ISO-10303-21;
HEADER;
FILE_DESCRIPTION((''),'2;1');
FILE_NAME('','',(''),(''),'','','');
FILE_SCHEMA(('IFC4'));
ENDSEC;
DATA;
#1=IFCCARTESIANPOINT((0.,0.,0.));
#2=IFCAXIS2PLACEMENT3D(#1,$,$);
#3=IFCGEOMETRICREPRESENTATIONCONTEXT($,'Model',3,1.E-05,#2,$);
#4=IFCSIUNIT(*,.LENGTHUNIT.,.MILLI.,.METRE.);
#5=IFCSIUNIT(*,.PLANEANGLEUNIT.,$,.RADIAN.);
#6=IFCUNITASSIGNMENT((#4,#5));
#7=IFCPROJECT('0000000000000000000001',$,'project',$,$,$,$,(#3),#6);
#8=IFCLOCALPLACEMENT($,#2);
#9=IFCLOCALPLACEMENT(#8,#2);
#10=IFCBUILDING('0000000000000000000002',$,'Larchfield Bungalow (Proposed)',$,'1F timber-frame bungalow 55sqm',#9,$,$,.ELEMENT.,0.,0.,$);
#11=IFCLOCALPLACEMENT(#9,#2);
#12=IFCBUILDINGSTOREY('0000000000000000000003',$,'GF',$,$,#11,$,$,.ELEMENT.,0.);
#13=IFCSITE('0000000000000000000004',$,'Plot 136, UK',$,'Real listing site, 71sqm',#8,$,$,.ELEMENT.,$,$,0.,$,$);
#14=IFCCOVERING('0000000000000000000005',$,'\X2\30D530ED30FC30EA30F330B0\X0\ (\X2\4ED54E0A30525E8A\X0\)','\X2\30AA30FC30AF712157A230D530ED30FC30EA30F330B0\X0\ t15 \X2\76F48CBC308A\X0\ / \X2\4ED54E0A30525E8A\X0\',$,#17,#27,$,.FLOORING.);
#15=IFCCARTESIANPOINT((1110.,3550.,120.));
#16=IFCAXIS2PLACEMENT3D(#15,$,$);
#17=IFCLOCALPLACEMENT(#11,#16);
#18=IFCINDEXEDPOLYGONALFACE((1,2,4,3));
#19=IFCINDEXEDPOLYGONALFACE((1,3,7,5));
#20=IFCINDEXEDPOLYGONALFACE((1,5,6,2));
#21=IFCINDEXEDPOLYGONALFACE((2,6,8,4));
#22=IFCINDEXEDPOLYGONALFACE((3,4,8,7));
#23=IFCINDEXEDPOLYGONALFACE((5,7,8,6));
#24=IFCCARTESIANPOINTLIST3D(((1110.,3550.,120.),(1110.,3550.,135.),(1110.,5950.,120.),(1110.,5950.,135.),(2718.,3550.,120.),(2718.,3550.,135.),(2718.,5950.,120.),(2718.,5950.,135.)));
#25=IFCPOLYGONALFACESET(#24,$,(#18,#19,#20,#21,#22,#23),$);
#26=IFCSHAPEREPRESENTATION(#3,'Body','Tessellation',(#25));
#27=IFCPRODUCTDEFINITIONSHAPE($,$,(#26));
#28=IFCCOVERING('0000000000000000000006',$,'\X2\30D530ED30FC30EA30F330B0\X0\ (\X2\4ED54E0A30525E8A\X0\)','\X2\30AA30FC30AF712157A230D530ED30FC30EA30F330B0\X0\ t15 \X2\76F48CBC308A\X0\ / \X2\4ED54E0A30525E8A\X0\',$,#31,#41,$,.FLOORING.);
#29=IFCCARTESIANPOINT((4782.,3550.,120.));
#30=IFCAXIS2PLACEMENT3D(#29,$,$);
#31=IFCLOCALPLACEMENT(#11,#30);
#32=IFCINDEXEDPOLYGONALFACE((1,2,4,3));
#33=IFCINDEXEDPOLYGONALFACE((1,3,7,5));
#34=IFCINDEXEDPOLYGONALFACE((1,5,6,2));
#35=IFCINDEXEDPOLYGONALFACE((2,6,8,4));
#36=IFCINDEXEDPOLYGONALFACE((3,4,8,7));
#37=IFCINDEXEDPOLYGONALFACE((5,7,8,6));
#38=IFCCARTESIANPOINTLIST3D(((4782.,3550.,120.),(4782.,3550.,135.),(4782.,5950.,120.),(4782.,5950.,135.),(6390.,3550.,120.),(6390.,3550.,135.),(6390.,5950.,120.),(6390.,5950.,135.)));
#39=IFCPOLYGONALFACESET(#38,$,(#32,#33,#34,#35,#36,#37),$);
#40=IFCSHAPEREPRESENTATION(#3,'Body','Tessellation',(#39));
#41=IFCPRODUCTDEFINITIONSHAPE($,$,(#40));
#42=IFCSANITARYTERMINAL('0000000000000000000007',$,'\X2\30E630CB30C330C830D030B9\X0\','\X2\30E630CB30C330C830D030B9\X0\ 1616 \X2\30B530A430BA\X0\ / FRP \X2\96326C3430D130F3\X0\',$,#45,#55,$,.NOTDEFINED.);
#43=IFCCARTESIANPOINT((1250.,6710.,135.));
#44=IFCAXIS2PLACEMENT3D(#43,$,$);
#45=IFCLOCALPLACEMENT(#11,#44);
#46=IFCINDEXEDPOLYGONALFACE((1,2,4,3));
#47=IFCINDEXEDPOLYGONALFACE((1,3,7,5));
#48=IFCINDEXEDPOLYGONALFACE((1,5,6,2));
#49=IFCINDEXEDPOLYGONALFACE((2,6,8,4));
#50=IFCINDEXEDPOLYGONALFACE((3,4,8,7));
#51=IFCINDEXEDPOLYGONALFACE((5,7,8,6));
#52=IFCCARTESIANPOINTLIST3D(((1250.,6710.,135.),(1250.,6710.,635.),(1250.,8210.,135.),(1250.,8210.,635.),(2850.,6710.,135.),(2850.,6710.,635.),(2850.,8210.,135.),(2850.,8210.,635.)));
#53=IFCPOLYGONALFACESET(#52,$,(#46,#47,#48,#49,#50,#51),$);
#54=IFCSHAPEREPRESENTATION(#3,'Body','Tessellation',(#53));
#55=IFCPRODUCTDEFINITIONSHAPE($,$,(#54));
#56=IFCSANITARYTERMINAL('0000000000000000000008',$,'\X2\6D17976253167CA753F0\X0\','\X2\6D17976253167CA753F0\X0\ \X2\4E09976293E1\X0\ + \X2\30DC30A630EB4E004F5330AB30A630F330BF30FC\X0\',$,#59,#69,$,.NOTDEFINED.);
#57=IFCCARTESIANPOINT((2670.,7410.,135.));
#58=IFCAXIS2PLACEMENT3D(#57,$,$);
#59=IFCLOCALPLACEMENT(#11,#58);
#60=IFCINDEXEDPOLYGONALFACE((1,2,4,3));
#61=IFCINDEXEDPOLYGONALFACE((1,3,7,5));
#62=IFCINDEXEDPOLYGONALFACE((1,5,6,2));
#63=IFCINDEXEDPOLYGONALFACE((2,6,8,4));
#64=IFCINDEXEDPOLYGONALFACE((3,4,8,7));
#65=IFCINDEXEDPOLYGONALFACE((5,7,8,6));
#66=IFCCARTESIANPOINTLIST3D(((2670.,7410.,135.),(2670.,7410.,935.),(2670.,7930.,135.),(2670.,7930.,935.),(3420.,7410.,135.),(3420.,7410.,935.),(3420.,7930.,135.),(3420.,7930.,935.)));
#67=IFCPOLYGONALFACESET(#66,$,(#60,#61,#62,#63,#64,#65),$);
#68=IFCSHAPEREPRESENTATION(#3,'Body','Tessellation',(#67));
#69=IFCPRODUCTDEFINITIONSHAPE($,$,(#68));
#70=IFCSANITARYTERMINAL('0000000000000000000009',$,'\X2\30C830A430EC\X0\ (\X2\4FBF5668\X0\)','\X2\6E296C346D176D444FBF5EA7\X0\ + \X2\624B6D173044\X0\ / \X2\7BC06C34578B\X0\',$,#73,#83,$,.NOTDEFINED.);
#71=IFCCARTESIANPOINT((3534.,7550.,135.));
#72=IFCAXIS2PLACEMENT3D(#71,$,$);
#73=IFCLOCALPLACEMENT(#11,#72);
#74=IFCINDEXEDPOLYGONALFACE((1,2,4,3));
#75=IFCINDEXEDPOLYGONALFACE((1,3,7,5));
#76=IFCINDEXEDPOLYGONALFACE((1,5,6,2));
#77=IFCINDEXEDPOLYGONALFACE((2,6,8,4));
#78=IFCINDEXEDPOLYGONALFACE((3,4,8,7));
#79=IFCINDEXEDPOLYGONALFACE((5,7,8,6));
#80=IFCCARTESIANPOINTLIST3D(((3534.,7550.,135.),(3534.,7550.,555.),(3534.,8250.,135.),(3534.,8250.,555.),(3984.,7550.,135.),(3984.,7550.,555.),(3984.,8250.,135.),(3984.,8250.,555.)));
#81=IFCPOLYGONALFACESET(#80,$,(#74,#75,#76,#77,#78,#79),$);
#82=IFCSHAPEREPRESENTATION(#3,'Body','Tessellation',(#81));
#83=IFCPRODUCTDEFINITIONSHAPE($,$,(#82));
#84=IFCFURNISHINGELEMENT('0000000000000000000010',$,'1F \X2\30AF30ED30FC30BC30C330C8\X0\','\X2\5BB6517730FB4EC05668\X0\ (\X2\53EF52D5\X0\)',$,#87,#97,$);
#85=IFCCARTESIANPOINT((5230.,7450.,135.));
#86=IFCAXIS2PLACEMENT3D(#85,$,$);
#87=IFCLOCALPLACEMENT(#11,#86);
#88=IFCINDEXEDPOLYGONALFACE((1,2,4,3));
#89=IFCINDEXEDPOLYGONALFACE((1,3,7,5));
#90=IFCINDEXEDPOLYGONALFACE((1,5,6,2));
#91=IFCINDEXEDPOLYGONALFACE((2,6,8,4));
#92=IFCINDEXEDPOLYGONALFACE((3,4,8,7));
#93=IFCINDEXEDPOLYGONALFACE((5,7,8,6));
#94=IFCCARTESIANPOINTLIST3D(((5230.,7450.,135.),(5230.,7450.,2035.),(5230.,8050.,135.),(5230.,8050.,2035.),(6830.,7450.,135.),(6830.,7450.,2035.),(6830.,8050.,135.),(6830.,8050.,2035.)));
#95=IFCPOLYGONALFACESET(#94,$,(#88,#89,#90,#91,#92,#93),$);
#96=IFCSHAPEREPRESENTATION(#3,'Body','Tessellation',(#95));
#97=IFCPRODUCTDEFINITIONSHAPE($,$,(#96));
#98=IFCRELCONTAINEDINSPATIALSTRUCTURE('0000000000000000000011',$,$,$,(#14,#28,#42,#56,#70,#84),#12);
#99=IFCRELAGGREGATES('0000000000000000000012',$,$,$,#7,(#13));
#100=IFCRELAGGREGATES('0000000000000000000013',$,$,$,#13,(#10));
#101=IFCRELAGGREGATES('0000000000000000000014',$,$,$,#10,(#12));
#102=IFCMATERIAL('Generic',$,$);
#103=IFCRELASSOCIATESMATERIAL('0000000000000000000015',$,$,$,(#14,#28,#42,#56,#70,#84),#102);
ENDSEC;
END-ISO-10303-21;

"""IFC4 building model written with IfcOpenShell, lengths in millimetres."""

from ifc_helpers import new_model, si_unit, frame, frame_2d, origin, place, context, project, spatial, rectangle, extrude, material, element, save


model = new_model("IFC4")

# Units and contexts
model_context = context("Model", 3, precision=1e-05, world=origin())
ifc_project = project(units=[si_unit("LENGTHUNIT", "METRE", prefix="MILLI"), si_unit("PLANEANGLEUNIT", "RADIAN")], contexts=[model_context])

# Site, building, storey
site_placement = place(None, origin())
site = spatial("IfcSite", under=ifc_project, at=site_placement, Name="Plot 136, UK", ObjectType="Real listing site, 71sqm", CompositionType="ELEMENT", RefElevation=0.0)
building_placement = place(site_placement, origin())
building = spatial("IfcBuilding", under=site, at=building_placement, Name="Larchfield Bungalow (Proposed)", ObjectType="1F timber-frame bungalow 55sqm", CompositionType="ELEMENT", ElevationOfRefHeight=0.0, ElevationOfTerrain=0.0)
storey_placement = place(building_placement, origin())
storey = spatial("IfcBuildingStorey", under=building, at=storey_placement, Name="GF", CompositionType="ELEMENT", Elevation=0.0)

# Coverings
ifc_material_1 = material(Name="Generic")
covering_1_placement = place(storey_placement, frame((1110.0, 3550.0, 120.0)))
element("IfcCovering", 1, at=covering_1_placement, inside=storey, material=ifc_material_1, Name="フローリング (仕上げ床)", Description="オーク無垢フローリング t15 直貼り / 仕上げ床", PredefinedType="FLOORING", context=model_context, shape_type="SweptSolid", body=[
    extrude(rectangle(XDim=1608.0, YDim=2400.0, at=frame_2d((804.0, 1200.0))), frame((1110.0, 3550.0, 120.0)), (0.0, 0.0, 1.0), 15.0),
])
covering_2_placement = place(storey_placement, frame((4782.0, 3550.0, 120.0)))
element("IfcCovering", 2, at=covering_2_placement, inside=storey, material=ifc_material_1, Name="フローリング (仕上げ床)", Description="オーク無垢フローリング t15 直貼り / 仕上げ床", PredefinedType="FLOORING", context=model_context, shape_type="SweptSolid", body=[
    extrude(rectangle(XDim=1608.0, YDim=2400.0, at=frame_2d((804.0, 1200.0))), frame((4782.0, 3550.0, 120.0)), (0.0, 0.0, 1.0), 15.0),
])

# Sanitary terminals
sanitary_terminal_1_placement = place(storey_placement, frame((1250.0, 6710.0, 135.0)))
element("IfcSanitaryTerminal", 3, at=sanitary_terminal_1_placement, inside=storey, material=ifc_material_1, Name="ユニットバス", Description="ユニットバス 1616 サイズ / FRP 防水パン", PredefinedType="NOTDEFINED", context=model_context, shape_type="SweptSolid", body=[
    extrude(rectangle(XDim=1600.0, YDim=1500.0, at=frame_2d((800.0, 750.0))), frame((1250.0, 6710.0, 135.0)), (0.0, 0.0, 1.0), 500.0),
])
sanitary_terminal_2_placement = place(storey_placement, frame((2670.0, 7410.0, 135.0)))
element("IfcSanitaryTerminal", 4, at=sanitary_terminal_2_placement, inside=storey, material=ifc_material_1, Name="洗面化粧台", Description="洗面化粧台 三面鏡 + ボウル一体カウンター", PredefinedType="NOTDEFINED", context=model_context, shape_type="SweptSolid", body=[
    extrude(rectangle(XDim=750.0, YDim=520.0, at=frame_2d((375.0, 260.0))), frame((2670.0, 7410.0, 135.0)), (0.0, 0.0, 1.0), 800.0),
])
sanitary_terminal_3_placement = place(storey_placement, frame((3534.0, 7550.0, 135.0)))
element("IfcSanitaryTerminal", 5, at=sanitary_terminal_3_placement, inside=storey, material=ifc_material_1, Name="トイレ (便器)", Description="温水洗浄便座 + 手洗い / 節水型", PredefinedType="NOTDEFINED", context=model_context, shape_type="SweptSolid", body=[
    extrude(rectangle(XDim=450.0, YDim=700.0, at=frame_2d((225.0, 350.0))), frame((3534.0, 7550.0, 135.0)), (0.0, 0.0, 1.0), 420.0),
])

# Furnishing element
furnishing_placement = place(storey_placement, frame((5230.0, 7450.0, 135.0)))
element("IfcFurnishingElement", 6, at=furnishing_placement, inside=storey, material=ifc_material_1, Name="1F クローゼット", Description="家具・什器 (可動)", context=model_context, shape_type="SweptSolid", body=[
    extrude(rectangle(XDim=1600.0, YDim=600.0, at=frame_2d((800.0, 300.0))), frame((5230.0, 7450.0, 135.0)), (0.0, 0.0, 1.0), 1900.0),
])

save(model, "model.ifc")
